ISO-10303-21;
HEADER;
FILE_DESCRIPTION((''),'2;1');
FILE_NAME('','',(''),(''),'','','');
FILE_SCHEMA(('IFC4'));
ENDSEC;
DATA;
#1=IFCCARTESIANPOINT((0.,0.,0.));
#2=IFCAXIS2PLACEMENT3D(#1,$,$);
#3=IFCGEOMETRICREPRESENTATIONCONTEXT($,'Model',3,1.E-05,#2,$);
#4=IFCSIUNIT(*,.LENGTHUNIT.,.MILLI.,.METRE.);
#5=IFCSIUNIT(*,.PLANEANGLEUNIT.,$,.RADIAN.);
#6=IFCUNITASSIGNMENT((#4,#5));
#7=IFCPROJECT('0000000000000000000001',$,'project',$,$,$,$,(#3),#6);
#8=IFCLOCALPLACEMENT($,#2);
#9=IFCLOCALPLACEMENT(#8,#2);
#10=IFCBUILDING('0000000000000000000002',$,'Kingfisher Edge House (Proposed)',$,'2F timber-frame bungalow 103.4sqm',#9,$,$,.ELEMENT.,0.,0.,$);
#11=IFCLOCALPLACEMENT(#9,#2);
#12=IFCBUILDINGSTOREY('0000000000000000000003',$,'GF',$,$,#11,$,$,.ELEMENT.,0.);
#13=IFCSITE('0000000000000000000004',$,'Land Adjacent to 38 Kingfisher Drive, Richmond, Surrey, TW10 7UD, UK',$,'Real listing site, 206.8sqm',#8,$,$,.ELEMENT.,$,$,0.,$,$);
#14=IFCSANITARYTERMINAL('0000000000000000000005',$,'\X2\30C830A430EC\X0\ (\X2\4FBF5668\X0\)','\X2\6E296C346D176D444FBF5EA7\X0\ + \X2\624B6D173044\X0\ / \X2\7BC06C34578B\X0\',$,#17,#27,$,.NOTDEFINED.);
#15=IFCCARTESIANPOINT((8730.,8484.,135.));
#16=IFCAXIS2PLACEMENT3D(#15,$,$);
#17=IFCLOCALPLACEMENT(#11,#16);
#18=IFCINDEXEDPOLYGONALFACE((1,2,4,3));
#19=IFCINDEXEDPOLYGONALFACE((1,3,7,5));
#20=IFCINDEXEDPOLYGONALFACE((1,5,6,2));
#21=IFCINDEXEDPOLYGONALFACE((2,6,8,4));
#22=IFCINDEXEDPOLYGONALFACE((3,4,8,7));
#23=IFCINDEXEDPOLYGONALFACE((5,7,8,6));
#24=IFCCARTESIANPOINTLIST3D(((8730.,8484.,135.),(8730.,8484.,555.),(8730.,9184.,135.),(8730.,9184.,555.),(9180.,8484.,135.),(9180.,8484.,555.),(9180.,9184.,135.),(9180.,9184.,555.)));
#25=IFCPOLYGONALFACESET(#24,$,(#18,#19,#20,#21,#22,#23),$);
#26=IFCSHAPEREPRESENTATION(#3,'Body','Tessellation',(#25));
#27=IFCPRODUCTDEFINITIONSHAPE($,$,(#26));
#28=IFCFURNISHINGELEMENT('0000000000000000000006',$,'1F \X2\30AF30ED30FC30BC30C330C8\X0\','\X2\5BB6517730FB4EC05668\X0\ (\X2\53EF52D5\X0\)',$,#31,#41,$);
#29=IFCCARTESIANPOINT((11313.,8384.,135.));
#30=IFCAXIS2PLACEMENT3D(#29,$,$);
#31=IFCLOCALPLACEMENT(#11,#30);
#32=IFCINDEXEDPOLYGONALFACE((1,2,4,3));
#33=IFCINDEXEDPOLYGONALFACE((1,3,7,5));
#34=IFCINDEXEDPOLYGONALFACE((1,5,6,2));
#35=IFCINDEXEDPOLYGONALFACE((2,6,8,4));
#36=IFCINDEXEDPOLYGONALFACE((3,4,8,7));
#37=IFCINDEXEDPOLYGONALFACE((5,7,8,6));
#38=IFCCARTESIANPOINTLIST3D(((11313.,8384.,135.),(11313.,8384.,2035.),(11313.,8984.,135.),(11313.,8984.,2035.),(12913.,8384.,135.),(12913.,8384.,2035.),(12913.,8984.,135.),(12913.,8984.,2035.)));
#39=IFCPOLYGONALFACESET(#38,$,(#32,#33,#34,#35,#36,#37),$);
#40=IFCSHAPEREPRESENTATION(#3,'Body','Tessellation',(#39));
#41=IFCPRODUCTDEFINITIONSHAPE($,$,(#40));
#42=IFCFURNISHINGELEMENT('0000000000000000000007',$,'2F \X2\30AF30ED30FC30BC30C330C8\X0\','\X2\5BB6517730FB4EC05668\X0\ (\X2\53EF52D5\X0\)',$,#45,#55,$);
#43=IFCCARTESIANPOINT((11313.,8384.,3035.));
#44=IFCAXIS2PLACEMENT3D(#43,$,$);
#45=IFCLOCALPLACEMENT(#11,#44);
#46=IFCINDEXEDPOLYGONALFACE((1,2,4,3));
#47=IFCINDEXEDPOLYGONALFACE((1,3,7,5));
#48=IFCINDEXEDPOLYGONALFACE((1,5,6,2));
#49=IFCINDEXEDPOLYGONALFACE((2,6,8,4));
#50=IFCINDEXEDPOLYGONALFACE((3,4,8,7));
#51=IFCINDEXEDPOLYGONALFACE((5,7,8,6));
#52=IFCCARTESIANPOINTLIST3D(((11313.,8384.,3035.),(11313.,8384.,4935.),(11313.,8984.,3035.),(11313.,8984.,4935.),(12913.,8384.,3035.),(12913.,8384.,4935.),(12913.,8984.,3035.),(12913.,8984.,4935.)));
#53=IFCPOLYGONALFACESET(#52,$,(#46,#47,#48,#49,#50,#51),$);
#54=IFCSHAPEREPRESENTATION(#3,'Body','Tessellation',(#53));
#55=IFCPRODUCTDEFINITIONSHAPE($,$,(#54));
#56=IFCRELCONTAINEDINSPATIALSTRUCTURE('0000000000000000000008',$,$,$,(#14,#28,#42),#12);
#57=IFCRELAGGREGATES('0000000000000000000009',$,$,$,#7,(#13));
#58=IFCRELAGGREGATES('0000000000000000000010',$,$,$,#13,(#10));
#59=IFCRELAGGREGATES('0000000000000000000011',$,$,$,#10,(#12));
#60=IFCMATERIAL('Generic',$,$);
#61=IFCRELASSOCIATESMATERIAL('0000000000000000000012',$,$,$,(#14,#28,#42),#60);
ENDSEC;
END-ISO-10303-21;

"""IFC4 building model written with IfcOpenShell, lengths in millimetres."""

from ifc_helpers import new_model, si_unit, frame, frame_2d, origin, place, context, project, spatial, rectangle, extrude, material, element, save


model = new_model("IFC4")

# Units and contexts
model_context = context("Model", 3, precision=1e-05, world=origin())
ifc_project = project(units=[si_unit("LENGTHUNIT", "METRE", prefix="MILLI"), si_unit("PLANEANGLEUNIT", "RADIAN")], contexts=[model_context])

# Site, building, storey
site_placement = place(None, origin())
site = spatial("IfcSite", under=ifc_project, at=site_placement, Name="Land Adjacent to 38 Kingfisher Drive, Richmond, Surrey, TW10 7UD, UK", ObjectType="Real listing site, 206.8sqm", CompositionType="ELEMENT", RefElevation=0.0)
building_placement = place(site_placement, origin())
building = spatial("IfcBuilding", under=site, at=building_placement, Name="Kingfisher Edge House (Proposed)", ObjectType="2F timber-frame bungalow 103.4sqm", CompositionType="ELEMENT", ElevationOfRefHeight=0.0, ElevationOfTerrain=0.0)
storey_placement = place(building_placement, origin())
storey = spatial("IfcBuildingStorey", under=building, at=storey_placement, Name="GF", CompositionType="ELEMENT", Elevation=0.0)

# Shared definitions
ifc_material_1 = material(Name="Generic")

# Sanitary terminal
sanitary_terminal_1_placement = place(storey_placement, frame((8730.0, 8484.0, 135.0)))
element("IfcSanitaryTerminal", 1, at=sanitary_terminal_1_placement, inside=storey, material=ifc_material_1, Name="トイレ (便器)", Description="温水洗浄便座 + 手洗い / 節水型", PredefinedType="NOTDEFINED", context=model_context, shape_type="SweptSolid", body=[
    extrude(rectangle(XDim=450.0, YDim=700.0, at=frame_2d((225.0, 350.0))), frame((8730.0, 8484.0, 135.0)), (0.0, 0.0, 1.0), 420.0),
])

# Furnishing elements
furnishing_1_placement = place(storey_placement, frame((11313.0, 8384.0, 135.0)))
element("IfcFurnishingElement", 2, at=furnishing_1_placement, inside=storey, material=ifc_material_1, Name="1F クローゼット", Description="家具・什器 (可動)", context=model_context, shape_type="SweptSolid", body=[
    extrude(rectangle(XDim=1600.0, YDim=600.0, at=frame_2d((800.0, 300.0))), frame((11313.0, 8384.0, 135.0)), (0.0, 0.0, 1.0), 1900.0),
])
furnishing_2_placement = place(storey_placement, frame((11313.0, 8384.0, 3035.0)))
element("IfcFurnishingElement", 3, at=furnishing_2_placement, inside=storey, material=ifc_material_1, Name="2F クローゼット", Description="家具・什器 (可動)", context=model_context, shape_type="SweptSolid", body=[
    extrude(rectangle(XDim=1600.0, YDim=600.0, at=frame_2d((800.0, 300.0))), frame((11313.0, 8384.0, 3035.0)), (0.0, 0.0, 1.0), 1900.0),
])

save(model, "model.ifc")
